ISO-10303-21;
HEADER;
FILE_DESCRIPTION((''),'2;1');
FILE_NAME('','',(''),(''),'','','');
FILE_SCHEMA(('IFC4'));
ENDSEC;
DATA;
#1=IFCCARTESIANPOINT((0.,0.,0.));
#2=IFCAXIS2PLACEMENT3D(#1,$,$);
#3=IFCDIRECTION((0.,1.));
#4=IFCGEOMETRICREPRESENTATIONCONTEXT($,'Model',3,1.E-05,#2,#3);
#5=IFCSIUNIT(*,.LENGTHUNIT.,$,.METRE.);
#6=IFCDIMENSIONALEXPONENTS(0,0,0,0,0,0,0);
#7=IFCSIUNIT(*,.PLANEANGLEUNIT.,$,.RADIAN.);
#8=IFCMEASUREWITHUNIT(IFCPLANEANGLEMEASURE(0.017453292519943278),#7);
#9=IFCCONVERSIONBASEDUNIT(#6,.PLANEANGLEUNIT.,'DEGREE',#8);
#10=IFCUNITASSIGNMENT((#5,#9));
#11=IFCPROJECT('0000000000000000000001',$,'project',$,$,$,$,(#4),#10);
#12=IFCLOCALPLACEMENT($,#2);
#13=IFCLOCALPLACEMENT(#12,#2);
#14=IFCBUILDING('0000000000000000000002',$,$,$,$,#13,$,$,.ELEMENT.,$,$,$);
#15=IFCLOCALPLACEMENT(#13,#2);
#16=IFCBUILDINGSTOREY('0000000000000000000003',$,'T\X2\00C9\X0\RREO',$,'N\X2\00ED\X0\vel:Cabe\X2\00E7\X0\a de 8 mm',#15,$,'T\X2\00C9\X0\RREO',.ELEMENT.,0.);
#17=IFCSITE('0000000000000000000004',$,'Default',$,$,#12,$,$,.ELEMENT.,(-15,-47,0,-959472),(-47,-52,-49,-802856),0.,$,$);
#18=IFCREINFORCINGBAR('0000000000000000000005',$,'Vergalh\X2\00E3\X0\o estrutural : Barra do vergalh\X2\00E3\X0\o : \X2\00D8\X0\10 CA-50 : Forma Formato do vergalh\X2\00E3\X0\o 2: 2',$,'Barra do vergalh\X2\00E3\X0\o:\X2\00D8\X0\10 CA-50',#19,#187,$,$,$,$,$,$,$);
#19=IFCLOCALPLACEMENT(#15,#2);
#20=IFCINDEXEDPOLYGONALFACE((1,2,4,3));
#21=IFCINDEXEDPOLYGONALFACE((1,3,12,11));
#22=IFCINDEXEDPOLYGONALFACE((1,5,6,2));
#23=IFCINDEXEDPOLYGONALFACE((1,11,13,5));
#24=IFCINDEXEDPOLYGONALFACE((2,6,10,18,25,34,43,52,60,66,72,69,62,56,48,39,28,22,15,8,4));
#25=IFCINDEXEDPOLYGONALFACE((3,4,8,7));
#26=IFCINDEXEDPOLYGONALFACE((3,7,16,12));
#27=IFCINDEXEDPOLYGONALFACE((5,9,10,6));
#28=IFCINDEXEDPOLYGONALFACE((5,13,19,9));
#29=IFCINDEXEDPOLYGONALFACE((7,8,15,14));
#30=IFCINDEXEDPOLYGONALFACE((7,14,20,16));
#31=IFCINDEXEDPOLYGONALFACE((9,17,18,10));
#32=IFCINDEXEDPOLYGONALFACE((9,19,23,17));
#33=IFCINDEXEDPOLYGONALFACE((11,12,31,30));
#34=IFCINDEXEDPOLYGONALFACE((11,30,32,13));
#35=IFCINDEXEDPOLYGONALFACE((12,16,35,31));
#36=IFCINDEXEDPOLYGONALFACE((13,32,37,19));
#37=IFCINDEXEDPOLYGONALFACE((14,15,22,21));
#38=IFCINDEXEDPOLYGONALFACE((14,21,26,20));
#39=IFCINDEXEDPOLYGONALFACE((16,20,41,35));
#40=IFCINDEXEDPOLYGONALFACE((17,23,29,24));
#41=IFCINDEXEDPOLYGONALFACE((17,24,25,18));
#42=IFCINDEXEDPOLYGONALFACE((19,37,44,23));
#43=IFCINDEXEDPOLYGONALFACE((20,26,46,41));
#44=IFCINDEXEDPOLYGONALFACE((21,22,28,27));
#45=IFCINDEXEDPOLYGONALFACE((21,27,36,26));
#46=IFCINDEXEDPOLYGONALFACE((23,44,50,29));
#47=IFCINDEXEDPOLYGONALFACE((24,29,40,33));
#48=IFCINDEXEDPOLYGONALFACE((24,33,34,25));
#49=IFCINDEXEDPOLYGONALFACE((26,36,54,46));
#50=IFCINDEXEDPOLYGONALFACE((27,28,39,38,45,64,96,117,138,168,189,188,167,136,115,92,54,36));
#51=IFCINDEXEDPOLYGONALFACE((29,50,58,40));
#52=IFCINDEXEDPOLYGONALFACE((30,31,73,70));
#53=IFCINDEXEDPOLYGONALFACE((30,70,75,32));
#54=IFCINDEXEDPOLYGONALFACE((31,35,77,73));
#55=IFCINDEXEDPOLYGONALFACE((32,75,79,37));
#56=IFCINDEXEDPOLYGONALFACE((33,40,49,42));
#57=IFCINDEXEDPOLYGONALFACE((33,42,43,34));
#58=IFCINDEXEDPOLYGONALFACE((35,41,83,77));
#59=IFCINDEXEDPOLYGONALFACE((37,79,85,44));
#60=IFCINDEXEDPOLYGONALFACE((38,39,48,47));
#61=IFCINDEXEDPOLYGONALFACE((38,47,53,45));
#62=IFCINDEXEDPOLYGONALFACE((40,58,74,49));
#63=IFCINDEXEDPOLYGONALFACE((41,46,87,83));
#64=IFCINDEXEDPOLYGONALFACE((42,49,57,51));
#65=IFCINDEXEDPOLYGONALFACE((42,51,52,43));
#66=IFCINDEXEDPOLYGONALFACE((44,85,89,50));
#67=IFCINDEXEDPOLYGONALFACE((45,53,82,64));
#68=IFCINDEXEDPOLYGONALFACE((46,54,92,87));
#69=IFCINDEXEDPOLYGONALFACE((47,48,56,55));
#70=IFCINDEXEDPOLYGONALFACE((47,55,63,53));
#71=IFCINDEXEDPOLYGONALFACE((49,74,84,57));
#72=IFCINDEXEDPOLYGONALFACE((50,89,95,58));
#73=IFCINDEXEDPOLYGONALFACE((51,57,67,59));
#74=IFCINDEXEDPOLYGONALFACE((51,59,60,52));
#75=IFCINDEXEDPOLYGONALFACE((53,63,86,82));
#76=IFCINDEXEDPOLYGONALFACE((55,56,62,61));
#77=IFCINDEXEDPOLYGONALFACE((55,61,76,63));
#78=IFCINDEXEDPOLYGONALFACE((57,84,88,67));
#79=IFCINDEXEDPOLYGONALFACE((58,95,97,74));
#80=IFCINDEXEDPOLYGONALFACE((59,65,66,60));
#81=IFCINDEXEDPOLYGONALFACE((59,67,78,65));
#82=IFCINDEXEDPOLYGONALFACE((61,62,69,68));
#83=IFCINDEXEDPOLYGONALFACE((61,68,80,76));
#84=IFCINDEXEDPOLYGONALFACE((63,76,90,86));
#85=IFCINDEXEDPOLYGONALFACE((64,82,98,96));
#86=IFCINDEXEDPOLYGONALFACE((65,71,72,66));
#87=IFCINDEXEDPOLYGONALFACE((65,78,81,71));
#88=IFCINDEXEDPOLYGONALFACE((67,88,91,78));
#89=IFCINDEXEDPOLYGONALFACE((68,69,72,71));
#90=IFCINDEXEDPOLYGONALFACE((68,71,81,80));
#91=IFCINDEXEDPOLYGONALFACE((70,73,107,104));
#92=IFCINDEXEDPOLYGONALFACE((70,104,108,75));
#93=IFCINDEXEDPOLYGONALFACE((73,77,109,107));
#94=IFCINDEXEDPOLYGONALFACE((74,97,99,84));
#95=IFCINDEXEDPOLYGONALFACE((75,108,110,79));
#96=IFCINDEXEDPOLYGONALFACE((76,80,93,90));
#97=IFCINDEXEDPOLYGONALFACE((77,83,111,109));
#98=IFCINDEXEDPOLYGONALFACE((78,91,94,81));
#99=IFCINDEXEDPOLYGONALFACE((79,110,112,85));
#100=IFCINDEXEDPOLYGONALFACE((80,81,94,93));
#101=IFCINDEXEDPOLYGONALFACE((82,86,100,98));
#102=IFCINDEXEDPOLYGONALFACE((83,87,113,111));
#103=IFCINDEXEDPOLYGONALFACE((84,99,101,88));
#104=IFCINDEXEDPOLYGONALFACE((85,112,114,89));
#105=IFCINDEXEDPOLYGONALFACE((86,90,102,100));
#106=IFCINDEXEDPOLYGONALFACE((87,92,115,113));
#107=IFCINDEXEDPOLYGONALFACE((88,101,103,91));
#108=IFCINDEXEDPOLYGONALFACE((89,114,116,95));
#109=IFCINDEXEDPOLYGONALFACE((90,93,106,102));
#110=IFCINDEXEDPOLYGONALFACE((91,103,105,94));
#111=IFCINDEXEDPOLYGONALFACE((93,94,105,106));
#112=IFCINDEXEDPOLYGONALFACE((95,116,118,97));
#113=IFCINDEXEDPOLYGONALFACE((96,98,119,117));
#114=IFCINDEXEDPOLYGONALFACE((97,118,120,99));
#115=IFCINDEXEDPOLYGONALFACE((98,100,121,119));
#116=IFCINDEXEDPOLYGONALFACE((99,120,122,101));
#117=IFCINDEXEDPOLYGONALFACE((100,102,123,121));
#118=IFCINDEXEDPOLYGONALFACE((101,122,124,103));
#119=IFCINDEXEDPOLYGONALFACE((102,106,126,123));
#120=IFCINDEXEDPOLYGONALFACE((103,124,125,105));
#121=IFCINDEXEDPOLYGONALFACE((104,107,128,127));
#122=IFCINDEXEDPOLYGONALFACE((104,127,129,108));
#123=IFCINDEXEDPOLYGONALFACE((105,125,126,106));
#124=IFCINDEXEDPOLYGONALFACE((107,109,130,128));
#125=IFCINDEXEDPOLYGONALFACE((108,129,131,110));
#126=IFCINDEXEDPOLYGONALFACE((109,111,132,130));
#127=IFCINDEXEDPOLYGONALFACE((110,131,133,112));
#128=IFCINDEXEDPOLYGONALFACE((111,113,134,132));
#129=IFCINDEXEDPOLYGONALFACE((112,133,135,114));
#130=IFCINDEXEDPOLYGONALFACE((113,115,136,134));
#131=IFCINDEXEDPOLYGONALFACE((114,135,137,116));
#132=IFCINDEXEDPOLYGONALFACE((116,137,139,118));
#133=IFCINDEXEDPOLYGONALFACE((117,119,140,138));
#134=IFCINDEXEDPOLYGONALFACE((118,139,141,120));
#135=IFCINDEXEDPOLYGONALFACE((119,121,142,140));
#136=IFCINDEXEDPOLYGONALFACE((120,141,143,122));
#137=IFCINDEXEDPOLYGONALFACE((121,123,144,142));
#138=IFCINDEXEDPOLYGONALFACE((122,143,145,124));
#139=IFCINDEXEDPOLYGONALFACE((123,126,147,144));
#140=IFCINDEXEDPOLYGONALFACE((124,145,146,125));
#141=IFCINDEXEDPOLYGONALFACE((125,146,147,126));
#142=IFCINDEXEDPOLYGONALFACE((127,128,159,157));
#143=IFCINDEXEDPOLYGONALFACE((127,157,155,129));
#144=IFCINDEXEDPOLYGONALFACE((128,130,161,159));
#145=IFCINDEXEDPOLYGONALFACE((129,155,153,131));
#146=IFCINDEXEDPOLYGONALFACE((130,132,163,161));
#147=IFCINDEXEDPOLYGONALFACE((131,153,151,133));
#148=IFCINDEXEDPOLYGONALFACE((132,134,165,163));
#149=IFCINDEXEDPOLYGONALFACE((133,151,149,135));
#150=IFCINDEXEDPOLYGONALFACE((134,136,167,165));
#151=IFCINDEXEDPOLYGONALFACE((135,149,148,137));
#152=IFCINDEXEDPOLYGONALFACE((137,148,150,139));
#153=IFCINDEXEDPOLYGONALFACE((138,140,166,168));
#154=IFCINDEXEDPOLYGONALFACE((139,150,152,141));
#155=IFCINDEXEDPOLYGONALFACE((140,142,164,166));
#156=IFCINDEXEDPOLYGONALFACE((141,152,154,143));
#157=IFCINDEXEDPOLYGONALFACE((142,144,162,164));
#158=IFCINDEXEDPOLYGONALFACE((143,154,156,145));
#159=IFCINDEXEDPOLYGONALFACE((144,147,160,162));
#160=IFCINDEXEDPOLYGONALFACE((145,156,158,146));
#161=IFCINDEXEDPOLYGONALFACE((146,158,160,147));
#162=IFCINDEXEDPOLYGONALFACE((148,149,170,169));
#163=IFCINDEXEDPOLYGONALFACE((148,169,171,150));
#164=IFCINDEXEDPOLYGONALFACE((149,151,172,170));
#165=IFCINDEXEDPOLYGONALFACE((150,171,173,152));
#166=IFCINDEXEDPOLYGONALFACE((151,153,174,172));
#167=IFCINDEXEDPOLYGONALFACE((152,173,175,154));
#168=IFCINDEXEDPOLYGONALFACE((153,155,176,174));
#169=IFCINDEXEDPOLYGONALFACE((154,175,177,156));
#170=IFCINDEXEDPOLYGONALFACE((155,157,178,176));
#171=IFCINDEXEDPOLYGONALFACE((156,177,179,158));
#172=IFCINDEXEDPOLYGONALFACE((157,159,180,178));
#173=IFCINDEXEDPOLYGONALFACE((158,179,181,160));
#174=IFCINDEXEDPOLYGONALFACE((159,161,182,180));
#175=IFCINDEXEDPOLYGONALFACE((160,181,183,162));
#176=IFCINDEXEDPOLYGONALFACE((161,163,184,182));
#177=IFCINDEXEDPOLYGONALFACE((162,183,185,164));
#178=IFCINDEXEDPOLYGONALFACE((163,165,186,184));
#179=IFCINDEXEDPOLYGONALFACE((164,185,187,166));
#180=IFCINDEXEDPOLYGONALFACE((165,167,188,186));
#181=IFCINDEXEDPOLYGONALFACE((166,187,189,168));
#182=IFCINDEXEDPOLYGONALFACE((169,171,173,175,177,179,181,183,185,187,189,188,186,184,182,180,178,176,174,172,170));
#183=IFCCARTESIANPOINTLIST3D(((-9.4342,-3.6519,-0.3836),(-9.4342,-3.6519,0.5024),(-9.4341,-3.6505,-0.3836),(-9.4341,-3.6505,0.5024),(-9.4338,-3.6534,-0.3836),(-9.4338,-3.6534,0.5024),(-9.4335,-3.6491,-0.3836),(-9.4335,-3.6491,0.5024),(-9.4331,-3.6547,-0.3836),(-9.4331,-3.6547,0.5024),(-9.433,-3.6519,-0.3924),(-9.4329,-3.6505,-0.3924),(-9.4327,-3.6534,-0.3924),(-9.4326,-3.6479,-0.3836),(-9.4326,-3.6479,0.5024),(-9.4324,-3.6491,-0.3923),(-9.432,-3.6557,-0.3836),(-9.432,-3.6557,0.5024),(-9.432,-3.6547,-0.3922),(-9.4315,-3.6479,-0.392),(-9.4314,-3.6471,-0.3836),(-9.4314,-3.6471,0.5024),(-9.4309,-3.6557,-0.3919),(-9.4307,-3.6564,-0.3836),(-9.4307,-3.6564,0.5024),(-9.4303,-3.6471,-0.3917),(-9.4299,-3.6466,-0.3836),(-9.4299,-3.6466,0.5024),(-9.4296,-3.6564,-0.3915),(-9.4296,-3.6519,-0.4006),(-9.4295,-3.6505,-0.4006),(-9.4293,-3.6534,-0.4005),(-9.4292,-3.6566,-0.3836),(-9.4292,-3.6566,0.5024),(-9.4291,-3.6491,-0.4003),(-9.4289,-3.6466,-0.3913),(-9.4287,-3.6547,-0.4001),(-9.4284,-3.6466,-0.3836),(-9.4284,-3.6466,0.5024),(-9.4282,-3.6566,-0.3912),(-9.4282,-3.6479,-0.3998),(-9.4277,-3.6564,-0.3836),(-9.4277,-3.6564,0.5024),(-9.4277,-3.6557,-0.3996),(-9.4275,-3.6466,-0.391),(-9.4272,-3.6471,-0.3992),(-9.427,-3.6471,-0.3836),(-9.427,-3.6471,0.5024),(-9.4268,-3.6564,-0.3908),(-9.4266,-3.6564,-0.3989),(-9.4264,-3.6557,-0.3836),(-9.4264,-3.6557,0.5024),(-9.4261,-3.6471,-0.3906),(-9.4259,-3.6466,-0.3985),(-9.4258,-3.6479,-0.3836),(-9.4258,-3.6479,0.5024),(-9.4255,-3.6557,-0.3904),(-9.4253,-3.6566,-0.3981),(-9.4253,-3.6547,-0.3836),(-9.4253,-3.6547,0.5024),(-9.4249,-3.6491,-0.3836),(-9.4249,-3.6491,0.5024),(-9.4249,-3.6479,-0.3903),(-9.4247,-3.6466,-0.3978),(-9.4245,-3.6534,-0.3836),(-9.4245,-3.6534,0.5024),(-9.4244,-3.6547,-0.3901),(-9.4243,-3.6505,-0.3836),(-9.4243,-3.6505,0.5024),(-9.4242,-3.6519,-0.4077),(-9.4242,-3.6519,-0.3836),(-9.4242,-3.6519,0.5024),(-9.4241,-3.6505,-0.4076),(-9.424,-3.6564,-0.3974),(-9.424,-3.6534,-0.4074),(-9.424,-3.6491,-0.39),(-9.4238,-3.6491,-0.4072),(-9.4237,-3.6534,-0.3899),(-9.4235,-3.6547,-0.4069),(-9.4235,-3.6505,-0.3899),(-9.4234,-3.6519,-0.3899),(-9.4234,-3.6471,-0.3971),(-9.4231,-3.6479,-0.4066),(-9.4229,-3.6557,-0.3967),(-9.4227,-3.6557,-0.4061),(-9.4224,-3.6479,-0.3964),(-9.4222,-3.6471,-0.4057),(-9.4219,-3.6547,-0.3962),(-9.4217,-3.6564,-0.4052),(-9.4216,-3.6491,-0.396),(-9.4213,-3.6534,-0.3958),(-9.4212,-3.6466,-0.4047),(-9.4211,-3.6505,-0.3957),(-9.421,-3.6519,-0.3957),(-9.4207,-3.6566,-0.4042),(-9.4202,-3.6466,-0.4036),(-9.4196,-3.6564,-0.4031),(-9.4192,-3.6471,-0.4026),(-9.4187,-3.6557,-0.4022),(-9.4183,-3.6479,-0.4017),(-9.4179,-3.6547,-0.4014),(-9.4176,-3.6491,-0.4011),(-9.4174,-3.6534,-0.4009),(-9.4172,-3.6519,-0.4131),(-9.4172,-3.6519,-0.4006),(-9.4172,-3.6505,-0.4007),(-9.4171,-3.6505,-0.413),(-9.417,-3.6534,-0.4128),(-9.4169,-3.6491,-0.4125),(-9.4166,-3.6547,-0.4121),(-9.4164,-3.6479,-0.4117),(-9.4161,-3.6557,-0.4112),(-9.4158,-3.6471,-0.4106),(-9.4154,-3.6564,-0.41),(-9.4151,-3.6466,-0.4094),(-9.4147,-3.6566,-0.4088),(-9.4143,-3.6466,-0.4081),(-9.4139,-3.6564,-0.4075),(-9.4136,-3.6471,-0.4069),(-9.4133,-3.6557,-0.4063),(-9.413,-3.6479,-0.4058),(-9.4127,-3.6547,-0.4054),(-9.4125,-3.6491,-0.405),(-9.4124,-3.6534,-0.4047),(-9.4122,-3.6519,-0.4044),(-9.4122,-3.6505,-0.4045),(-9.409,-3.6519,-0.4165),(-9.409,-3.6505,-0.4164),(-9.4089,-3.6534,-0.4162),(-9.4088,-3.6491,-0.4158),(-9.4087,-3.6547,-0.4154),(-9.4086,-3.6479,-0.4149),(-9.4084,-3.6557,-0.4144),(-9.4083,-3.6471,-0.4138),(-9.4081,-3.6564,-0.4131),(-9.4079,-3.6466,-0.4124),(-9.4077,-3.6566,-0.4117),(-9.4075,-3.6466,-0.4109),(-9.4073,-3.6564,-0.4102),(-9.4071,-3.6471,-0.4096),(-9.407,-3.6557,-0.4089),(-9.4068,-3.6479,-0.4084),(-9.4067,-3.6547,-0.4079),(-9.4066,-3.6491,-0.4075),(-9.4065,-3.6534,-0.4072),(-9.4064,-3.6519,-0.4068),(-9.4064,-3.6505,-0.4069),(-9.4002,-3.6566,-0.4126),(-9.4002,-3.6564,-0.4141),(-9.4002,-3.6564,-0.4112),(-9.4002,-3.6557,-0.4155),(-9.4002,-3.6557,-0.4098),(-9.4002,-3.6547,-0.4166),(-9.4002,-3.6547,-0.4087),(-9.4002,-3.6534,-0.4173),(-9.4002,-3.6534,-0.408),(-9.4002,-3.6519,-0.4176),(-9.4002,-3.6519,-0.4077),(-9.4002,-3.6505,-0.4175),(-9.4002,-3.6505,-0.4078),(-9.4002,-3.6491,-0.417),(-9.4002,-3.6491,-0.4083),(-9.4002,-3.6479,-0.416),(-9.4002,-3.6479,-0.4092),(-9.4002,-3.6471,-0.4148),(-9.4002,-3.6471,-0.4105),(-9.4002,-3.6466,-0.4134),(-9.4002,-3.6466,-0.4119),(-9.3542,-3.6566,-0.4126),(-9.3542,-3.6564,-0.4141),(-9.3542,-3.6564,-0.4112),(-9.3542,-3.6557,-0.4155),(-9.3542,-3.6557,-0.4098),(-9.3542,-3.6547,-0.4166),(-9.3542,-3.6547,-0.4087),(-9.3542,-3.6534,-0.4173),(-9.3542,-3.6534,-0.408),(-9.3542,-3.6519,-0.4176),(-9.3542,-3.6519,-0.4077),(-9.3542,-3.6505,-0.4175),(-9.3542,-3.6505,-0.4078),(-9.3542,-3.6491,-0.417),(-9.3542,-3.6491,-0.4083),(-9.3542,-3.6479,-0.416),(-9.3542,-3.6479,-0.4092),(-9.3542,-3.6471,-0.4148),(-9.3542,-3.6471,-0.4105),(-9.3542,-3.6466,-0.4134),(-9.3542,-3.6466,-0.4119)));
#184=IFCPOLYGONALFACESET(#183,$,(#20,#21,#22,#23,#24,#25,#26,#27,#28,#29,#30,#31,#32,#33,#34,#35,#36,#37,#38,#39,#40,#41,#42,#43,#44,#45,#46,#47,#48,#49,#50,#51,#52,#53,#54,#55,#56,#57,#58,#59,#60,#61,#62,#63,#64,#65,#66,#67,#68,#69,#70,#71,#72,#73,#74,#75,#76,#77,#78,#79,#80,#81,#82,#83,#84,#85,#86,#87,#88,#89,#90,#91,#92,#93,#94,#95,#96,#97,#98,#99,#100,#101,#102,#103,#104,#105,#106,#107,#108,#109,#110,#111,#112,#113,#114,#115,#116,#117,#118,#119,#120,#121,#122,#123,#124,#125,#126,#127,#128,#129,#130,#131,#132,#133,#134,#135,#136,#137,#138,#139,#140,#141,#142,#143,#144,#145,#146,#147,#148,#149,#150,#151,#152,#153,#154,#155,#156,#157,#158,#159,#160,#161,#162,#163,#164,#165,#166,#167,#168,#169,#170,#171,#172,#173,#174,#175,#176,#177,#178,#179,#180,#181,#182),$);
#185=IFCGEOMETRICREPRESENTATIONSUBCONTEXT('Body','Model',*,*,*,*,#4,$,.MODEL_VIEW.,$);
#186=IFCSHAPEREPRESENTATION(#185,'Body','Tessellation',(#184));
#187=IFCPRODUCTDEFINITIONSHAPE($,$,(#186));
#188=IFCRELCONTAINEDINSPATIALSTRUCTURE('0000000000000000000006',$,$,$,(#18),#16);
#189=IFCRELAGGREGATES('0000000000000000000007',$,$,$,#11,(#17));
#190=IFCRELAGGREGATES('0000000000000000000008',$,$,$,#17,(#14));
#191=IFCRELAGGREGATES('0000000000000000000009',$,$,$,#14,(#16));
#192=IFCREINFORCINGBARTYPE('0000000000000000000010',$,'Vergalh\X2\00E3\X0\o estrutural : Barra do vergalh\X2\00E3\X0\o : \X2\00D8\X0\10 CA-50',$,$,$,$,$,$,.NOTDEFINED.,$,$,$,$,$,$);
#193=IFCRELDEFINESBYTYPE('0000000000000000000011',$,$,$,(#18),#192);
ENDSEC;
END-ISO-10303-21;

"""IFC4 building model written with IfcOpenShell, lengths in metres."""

from ifc_helpers import new_model, entity, si_unit, converted_unit, direction, origin, place, context, subcontext, project, spatial, type_object, element, save


model = new_model("IFC4")

# Units and contexts
model_context = context("Model", 3, precision=1e-05, world=origin(), true_north=direction((0.0, 1.0)))
body_context = subcontext(model_context, "Body", "Model", "MODEL_VIEW")
ifc_project = project(units=[si_unit("LENGTHUNIT", "METRE"), converted_unit("PLANEANGLEUNIT", "DEGREE", entity("IfcPlaneAngleMeasure", 0.017453292519943278), si_unit("PLANEANGLEUNIT", "RADIAN"), dimensions=[0, 0, 0, 0, 0, 0, 0])], contexts=[model_context])

# Site, building, storey
site_placement = place(None, origin())
site = spatial("IfcSite", under=ifc_project, at=site_placement, Name="Default", CompositionType="ELEMENT", RefLatitude=(-15, -47, 0, -959472), RefLongitude=(-47, -52, -49, -802856), RefElevation=0.0)
building_placement = place(site_placement, origin())
building = spatial("IfcBuilding", under=site, at=building_placement, CompositionType="ELEMENT")
storey_placement = place(building_placement, origin())
storey = spatial("IfcBuildingStorey", under=building, at=storey_placement, Name="TÉRREO", ObjectType="Nível:Cabeça de 8 mm", LongName="TÉRREO", CompositionType="ELEMENT", Elevation=0.0)

# Reinforcing bar
reinforcing_bar_type_1 = type_object("IfcReinforcingBarType", Name="Vergalhão estrutural : Barra do vergalhão : Ø10 CA-50", PredefinedType="NOTDEFINED")
reinforcing_bar_1_placement = place(storey_placement, origin())
element("IfcReinforcingBar", 1, at=reinforcing_bar_1_placement, inside=storey, type_object=reinforcing_bar_type_1, Name="Vergalhão estrutural : Barra do vergalhão : Ø10 CA-50 : Forma Formato do vergalhão 2: 2", ObjectType="Barra do vergalhão:Ø10 CA-50", context=body_context, shape_type="AdvancedSweptSolid", body=[
    entity("IfcSweptDiskSolid", entity("IfcIndexedPolyCurve", entity("IfcCartesianPointList3D", [[-9.3542, -3.6516, -0.4126], [-9.4002, -3.6516, -0.4126], [-9.4207, -3.6516, -0.4042], [-9.4292, -3.6516, -0.3836], [-9.4292, -3.6516, 0.5024]]), [entity("IfcLineIndex", [1, 2]), entity("IfcArcIndex", [2, 3, 4]), entity("IfcLineIndex", [4, 5])], False), 0.005, None, 0.0, 92.0),
])

save(model, "model.ifc")
